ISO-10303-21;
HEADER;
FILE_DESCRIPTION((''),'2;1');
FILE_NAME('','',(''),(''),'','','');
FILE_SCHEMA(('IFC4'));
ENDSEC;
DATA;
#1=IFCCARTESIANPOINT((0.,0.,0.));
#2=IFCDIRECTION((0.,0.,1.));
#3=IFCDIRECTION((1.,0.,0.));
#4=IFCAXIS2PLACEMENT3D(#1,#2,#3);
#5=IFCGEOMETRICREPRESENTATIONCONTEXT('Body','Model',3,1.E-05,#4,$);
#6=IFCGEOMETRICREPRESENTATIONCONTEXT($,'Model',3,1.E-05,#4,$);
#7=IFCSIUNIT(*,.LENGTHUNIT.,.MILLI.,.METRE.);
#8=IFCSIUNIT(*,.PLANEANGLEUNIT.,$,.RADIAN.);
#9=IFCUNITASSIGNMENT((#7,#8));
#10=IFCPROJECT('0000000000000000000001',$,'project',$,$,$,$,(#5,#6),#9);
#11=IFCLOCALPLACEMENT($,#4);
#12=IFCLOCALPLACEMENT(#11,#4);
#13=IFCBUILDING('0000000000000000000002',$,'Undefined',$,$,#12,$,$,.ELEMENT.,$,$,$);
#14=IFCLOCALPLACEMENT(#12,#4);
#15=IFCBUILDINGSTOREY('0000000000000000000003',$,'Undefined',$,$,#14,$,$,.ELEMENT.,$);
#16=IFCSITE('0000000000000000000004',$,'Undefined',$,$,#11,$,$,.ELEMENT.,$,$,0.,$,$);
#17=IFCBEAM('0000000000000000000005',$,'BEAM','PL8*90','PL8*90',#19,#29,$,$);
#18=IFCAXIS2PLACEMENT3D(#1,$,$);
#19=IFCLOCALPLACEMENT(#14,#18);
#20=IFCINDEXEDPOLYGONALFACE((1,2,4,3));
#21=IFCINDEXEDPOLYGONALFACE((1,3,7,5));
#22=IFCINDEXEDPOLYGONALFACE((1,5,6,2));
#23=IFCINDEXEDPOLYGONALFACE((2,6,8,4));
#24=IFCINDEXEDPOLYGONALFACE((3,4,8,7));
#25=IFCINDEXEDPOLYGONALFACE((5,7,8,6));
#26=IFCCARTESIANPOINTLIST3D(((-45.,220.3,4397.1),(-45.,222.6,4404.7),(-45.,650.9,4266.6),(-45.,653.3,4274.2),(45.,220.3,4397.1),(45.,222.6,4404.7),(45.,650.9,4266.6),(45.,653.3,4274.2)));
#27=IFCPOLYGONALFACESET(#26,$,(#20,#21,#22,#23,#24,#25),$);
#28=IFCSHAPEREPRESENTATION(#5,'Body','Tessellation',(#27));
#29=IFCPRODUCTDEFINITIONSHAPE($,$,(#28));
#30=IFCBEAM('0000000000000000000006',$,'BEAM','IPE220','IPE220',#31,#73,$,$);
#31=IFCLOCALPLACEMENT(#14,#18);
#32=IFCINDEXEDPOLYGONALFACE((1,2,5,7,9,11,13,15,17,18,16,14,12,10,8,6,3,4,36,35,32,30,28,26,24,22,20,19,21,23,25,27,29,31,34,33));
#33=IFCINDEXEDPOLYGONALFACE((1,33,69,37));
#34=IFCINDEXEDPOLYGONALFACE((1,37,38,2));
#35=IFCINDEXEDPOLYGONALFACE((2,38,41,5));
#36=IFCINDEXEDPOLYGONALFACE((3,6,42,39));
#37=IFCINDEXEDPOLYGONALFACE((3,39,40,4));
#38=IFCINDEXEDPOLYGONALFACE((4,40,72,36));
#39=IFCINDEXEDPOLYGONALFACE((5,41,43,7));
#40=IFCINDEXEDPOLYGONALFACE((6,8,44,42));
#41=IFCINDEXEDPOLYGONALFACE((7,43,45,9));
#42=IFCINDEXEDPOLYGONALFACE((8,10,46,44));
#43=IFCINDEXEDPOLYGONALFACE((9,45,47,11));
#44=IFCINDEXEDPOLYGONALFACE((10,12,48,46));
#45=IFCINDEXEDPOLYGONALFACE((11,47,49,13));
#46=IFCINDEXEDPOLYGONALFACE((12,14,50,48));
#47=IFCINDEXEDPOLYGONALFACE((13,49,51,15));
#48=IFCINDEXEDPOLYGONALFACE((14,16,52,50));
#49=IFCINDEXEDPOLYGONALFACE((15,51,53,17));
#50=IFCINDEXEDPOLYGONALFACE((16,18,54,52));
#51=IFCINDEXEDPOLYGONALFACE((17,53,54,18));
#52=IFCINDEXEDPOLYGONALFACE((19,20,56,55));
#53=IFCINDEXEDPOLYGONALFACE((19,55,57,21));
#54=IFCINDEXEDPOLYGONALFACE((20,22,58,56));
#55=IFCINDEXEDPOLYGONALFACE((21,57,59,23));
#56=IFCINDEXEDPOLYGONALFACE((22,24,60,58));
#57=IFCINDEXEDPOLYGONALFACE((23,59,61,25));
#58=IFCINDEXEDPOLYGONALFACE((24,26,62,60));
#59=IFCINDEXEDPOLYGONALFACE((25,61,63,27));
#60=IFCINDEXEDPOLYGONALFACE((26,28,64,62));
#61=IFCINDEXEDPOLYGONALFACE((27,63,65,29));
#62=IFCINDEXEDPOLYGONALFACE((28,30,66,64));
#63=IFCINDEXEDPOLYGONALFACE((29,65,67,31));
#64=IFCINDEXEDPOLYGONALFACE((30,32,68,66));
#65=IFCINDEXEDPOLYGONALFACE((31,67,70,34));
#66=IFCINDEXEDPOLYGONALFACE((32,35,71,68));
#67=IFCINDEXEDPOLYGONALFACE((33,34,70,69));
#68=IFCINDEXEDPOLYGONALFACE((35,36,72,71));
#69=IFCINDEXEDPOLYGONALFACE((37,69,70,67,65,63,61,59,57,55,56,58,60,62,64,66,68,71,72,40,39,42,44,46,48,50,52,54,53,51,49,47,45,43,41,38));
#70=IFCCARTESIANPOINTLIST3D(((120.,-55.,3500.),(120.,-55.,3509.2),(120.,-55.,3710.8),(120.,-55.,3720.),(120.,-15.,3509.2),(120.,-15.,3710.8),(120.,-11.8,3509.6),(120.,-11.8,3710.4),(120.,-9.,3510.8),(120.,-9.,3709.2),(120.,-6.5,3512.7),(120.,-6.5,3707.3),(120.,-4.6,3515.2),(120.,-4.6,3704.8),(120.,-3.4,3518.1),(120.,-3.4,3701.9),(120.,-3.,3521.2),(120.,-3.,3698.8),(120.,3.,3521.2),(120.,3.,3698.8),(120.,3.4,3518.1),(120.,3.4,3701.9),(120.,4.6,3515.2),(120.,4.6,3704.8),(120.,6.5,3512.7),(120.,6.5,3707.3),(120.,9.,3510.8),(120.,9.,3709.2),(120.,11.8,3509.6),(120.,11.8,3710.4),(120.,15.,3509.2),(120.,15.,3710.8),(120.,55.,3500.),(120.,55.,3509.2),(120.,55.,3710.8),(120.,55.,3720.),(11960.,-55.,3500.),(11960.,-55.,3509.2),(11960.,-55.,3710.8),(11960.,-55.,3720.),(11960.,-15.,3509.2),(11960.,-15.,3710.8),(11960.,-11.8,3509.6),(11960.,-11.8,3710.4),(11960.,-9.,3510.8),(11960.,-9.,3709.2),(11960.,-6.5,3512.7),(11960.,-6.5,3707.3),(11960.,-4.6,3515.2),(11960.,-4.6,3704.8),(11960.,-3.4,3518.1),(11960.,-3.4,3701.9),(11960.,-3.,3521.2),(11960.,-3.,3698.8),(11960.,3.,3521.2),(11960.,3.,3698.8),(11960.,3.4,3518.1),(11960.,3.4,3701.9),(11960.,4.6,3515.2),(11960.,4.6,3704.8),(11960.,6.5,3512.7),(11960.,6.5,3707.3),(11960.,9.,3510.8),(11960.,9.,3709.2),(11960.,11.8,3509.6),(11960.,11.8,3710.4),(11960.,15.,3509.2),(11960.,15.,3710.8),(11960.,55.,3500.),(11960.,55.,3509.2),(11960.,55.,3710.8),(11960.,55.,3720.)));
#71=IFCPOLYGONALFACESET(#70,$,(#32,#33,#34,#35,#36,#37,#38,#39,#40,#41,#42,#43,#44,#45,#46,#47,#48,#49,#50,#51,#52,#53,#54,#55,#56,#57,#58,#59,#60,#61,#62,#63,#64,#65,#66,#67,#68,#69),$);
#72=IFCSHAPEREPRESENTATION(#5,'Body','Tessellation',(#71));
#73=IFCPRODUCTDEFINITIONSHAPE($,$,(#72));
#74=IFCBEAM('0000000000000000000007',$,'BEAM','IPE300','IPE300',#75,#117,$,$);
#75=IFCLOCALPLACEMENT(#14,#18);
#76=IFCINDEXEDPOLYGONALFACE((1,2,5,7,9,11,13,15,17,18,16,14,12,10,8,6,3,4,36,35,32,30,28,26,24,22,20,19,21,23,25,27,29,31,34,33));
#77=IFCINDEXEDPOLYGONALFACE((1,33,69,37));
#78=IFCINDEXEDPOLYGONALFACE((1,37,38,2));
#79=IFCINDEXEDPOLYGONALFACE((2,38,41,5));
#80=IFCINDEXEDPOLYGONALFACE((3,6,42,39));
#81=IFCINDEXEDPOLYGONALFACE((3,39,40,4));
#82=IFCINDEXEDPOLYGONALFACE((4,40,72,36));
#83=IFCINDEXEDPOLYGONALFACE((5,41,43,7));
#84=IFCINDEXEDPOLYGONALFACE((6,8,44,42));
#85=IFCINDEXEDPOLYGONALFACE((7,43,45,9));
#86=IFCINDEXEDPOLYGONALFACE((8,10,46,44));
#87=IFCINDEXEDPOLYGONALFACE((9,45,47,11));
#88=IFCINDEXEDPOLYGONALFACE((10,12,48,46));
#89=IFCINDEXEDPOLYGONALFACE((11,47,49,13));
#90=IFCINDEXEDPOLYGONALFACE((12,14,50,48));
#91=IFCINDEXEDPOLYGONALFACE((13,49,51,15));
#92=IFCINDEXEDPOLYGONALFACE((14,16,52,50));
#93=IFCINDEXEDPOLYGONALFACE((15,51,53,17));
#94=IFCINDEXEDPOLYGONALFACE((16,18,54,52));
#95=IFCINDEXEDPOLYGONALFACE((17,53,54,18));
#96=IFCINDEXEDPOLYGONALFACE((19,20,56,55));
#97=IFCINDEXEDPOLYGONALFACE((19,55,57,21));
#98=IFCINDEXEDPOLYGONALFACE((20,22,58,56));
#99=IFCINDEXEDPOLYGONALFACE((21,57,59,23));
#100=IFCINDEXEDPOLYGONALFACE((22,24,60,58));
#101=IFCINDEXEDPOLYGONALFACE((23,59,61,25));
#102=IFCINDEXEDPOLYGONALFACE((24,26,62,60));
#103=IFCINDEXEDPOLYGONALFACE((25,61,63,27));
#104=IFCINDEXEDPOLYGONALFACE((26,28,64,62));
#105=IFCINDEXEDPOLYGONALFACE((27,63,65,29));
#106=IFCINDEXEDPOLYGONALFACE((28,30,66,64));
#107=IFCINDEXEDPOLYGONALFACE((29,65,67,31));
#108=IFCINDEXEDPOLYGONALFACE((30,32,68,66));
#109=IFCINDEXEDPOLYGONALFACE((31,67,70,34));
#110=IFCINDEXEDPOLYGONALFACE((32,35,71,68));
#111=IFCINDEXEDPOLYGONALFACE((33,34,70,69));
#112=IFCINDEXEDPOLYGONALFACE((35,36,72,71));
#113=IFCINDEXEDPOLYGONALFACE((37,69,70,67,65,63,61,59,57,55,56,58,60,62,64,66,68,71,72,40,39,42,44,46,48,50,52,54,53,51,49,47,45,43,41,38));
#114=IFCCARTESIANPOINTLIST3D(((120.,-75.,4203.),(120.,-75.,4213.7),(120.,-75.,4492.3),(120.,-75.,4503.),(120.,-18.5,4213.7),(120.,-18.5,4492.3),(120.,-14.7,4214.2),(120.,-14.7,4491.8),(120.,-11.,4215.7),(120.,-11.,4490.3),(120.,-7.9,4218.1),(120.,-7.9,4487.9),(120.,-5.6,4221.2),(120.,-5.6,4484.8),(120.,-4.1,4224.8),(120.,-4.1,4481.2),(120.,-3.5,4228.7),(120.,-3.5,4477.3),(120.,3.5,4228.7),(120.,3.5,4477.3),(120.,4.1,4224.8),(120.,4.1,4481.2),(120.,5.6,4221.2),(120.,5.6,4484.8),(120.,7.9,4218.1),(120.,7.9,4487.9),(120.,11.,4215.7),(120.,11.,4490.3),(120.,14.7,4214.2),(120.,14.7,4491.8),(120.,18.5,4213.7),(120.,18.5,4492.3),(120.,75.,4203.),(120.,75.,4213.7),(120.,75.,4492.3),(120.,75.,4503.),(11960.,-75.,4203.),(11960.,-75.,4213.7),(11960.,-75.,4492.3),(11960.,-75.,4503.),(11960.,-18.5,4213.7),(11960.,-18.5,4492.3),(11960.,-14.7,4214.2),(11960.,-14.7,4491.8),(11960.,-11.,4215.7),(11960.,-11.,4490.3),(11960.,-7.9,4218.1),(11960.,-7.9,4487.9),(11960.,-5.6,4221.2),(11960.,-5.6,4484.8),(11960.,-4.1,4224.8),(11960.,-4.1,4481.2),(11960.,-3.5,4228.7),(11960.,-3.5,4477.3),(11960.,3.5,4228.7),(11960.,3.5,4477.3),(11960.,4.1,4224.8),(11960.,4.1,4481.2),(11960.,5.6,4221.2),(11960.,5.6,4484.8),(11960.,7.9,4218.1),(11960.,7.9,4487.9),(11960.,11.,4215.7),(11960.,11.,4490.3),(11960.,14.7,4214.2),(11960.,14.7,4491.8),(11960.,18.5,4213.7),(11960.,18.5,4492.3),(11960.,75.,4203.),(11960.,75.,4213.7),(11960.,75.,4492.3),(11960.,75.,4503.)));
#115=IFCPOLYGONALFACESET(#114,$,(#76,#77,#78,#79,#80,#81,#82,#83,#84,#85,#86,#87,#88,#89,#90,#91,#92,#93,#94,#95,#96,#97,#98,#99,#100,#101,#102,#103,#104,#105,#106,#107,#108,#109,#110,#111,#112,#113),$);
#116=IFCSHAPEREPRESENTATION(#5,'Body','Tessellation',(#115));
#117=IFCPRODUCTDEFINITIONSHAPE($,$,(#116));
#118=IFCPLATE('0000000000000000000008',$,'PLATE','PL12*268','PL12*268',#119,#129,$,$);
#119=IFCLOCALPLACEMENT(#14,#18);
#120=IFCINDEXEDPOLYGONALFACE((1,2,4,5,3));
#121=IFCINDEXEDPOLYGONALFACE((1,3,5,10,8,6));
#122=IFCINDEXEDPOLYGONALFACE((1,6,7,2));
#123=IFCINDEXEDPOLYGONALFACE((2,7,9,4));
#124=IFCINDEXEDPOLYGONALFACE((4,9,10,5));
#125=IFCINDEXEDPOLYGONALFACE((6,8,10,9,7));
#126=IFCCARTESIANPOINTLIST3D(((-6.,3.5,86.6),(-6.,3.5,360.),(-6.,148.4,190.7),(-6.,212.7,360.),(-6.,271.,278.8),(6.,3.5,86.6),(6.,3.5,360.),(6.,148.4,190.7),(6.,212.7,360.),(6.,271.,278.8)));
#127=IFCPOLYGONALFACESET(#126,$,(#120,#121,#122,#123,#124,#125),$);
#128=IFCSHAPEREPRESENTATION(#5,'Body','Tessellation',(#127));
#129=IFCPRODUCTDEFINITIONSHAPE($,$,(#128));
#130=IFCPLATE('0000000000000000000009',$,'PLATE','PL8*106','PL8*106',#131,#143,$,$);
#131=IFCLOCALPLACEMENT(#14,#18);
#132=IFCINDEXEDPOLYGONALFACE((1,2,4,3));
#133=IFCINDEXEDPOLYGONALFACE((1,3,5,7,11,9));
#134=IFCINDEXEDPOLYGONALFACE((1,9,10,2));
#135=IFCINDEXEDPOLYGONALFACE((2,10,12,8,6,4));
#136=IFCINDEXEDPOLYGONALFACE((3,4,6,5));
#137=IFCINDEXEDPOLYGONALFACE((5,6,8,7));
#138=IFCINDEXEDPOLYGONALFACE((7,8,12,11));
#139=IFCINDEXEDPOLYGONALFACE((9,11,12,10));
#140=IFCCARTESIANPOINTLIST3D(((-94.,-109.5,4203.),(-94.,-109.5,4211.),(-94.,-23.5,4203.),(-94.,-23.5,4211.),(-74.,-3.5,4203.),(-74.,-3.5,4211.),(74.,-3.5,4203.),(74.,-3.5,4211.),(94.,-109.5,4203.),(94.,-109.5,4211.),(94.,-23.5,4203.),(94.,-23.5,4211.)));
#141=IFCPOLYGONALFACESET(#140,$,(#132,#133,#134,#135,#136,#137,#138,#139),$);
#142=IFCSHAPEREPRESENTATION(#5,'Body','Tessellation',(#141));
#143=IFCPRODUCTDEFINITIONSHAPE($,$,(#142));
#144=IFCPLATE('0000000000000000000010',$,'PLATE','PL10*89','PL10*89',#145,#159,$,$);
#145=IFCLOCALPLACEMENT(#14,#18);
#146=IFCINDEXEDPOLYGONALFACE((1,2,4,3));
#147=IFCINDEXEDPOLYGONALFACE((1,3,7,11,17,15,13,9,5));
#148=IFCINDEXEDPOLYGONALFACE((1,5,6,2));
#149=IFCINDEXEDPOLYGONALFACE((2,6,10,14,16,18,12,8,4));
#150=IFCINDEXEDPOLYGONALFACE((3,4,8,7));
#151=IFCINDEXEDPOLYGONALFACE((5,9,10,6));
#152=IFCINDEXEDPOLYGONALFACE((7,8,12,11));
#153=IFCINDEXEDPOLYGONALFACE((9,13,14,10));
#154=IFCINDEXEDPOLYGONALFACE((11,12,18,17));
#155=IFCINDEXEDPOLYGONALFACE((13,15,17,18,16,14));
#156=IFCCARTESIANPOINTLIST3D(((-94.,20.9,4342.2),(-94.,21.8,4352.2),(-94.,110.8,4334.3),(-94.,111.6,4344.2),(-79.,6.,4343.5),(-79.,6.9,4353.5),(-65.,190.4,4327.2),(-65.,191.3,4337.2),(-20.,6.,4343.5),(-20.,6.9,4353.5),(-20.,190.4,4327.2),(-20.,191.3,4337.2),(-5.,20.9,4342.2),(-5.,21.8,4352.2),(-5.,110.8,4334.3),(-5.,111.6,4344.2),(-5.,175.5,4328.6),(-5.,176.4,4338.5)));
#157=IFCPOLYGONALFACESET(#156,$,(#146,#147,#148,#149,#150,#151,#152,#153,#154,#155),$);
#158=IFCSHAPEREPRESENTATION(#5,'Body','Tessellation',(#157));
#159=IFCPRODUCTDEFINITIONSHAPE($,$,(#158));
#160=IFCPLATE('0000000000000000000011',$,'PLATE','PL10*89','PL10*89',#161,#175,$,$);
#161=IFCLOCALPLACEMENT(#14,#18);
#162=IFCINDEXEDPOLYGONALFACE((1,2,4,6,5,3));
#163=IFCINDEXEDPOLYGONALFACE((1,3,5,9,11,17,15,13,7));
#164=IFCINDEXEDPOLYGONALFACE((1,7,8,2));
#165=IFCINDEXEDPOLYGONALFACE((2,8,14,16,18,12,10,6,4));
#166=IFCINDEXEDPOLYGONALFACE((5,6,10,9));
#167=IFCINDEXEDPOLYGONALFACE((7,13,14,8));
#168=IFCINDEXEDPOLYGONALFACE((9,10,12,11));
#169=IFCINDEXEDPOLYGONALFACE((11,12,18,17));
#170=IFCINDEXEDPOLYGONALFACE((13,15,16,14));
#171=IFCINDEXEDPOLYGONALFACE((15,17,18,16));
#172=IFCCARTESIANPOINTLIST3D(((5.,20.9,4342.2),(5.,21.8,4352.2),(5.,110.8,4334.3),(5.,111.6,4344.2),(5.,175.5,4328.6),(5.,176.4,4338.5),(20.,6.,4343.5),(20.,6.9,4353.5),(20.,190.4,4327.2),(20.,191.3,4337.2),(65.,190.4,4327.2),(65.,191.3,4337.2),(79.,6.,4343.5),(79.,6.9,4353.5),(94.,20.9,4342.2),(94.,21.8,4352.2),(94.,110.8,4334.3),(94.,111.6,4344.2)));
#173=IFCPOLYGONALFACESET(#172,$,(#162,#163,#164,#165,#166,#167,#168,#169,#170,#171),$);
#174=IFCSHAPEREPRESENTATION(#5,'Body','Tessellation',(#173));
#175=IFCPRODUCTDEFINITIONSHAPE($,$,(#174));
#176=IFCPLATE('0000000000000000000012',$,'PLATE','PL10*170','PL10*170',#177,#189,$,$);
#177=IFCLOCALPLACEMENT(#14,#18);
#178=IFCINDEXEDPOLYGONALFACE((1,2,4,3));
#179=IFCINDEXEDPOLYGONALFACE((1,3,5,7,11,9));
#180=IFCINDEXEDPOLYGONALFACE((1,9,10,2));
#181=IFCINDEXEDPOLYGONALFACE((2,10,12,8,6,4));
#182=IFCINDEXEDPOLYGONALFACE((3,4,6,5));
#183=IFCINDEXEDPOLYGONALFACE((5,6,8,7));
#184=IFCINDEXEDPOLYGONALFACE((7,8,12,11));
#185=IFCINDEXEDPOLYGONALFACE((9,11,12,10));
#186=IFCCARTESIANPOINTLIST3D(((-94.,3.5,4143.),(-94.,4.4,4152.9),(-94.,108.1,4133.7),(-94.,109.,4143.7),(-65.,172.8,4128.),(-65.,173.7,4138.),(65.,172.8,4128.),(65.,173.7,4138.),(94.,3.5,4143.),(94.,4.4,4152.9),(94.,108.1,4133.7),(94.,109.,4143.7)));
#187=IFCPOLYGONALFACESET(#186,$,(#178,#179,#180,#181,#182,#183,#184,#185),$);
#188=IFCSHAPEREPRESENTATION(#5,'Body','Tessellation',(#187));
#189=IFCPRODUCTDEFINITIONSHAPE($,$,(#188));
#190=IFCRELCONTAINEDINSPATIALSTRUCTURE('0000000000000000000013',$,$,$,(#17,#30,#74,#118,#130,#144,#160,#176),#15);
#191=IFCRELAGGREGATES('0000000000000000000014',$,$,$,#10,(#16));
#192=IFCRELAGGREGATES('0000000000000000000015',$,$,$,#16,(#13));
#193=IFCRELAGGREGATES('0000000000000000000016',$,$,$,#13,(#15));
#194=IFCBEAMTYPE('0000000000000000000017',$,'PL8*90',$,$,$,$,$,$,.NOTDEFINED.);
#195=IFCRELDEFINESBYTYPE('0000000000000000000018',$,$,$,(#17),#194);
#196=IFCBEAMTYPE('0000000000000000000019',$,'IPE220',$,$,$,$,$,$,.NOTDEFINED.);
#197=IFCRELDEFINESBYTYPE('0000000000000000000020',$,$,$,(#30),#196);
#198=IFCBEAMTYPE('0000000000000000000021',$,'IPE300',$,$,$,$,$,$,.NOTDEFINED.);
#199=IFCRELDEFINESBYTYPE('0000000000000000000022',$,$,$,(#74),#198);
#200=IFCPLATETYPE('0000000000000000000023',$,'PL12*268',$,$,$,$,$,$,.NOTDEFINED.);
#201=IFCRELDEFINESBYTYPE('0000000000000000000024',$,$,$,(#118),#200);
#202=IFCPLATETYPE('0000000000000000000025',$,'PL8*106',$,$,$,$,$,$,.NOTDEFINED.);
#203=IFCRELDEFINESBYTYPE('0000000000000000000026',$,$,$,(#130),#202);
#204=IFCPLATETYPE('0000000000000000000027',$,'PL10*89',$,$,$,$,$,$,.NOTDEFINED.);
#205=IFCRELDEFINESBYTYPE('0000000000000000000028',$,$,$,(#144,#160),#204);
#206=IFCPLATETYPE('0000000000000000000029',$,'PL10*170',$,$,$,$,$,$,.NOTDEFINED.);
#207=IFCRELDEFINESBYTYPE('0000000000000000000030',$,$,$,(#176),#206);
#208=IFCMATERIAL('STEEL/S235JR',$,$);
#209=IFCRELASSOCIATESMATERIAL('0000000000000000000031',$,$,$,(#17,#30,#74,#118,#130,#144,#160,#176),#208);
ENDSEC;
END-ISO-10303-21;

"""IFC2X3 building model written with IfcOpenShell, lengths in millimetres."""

from ifc_helpers import new_model, si_unit, frame, origin_with_axes, origin_2d_with_axis, place, context, project, spatial, polyline, rectangle, i_section, outline, extrude, material, type_object, element, save


model = new_model("IFC2X3")

# Units and contexts
model_context_1 = context("Model", 3, precision=1e-05, world=origin_with_axes(), identifier="Body")
model_context_2 = context("Model", 3, precision=1e-05, world=origin_with_axes())
ifc_project = project(units=[si_unit("LENGTHUNIT", "METRE", prefix="MILLI"), si_unit("PLANEANGLEUNIT", "RADIAN")], contexts=[model_context_1, model_context_2])

# Site, building, storey
site_placement = place(None, origin_with_axes())
site = spatial("IfcSite", under=ifc_project, at=site_placement, Name="Undefined", CompositionType="ELEMENT", RefElevation=0.0)
building_placement = place(site_placement, origin_with_axes())
building = spatial("IfcBuilding", under=site, at=building_placement, Name="Undefined", CompositionType="ELEMENT")
storey_placement = place(building_placement, origin_with_axes())
storey = spatial("IfcBuildingStorey", under=building, at=storey_placement, Name="Undefined", CompositionType="ELEMENT")

# Shared definitions
ifc_material = material(Name="STEEL/S235JR")

# Beams
beam_type_1 = type_object("IfcBeamType", Name="PL8*90", PredefinedType="NOTDEFINED")
beam_1_placement = place(storey_placement, frame((0.0, 221.4, 4400.9), z_axis=(-1.0, 0.0, 0.0), x_axis=(0.0, 0.957026, -0.290002)))
element("IfcBeam", 1, at=beam_1_placement, inside=storey, type_object=beam_type_1, material=ifc_material, Name="BEAM", Description="PL8*90", ObjectType="PL8*90", context=model_context_1, shape_type="SweptSolid", body=[
    extrude(rectangle(XDim=8.0, YDim=90.0, at=origin_2d_with_axis()), frame((450.0, 0.0, 0.0), z_axis=(-1.0, 0.0, 0.0), x_axis=(0.0, -1.0, 0.0)), (0.0, 0.0, 1.0), 450.0),
])
beam_type_2 = type_object("IfcBeamType", Name="IPE220", PredefinedType="NOTDEFINED")
beam_2_placement = place(storey_placement, frame((40.0, 0.0, 3610.0), z_axis=(0.0, 0.0, 1.0), x_axis=(1.0, 0.0, 0.0)))
element("IfcBeam", 2, at=beam_2_placement, inside=storey, type_object=beam_type_2, material=ifc_material, Name="BEAM", Description="IPE220", ObjectType="IPE220", context=model_context_1, shape_type="SweptSolid", body=[
    extrude(i_section(OverallWidth=110.0, OverallDepth=220.0, WebThickness=5.9, FlangeThickness=9.2, FilletRadius=12.0, at=origin_2d_with_axis()), frame((11920.0, 0.0, 0.0), z_axis=(-1.0, 0.0, 0.0), x_axis=(0.0, -1.0, 0.0)), (0.0, 0.0, 1.0), 11840.0),
])
beam_type_3 = type_object("IfcBeamType", Name="IPE300", PredefinedType="NOTDEFINED")
beam_3_placement = place(storey_placement, frame((40.0, 0.0, 4353.0), z_axis=(0.0, 0.0, 1.0), x_axis=(1.0, 0.0, 0.0)))
element("IfcBeam", 3, at=beam_3_placement, inside=storey, type_object=beam_type_3, material=ifc_material, Name="BEAM", Description="IPE300", ObjectType="IPE300", context=model_context_1, shape_type="SweptSolid", body=[
    extrude(i_section(OverallWidth=150.0, OverallDepth=300.0, WebThickness=7.1, FlangeThickness=10.7, FilletRadius=15.0, at=origin_2d_with_axis()), frame((11920.0, 0.0, 0.0), z_axis=(-1.0, 0.0, 0.0), x_axis=(0.0, -1.0, 0.0)), (0.0, 0.0, 1.0), 11840.0),
])

# Plates
plate_type_1 = type_object("IfcPlateType", Name="PL12*268", PredefinedType="NOTDEFINED")
plate_1_placement = place(storey_placement, frame((0.0, 3.5, 86.6), z_axis=(-1.0, 0.0, 0.0), x_axis=(0.0, 0.0, 1.0)))
element("IfcPlate", 4, at=plate_1_placement, inside=storey, type_object=plate_type_1, material=ifc_material, Name="PLATE", Description="PL12*268", ObjectType="PL12*268", context=model_context_1, shape_type="SweptSolid", body=[
    extrude(outline(polyline([(0.0, 0.0), (273.4, 0.0), (273.4, 209.2), (192.2, 267.5), (104.1, 144.9), (0.0, 0.0)])), frame((0.0, 0.0, -6.0), z_axis=(0.0, 0.0, 1.0), x_axis=(1.0, 0.0, 0.0)), (0.0, 0.0, 1.0), 12.0),
])
plate_type_2 = type_object("IfcPlateType", Name="PL8*106", PredefinedType="NOTDEFINED")
plate_2_placement = place(storey_placement, frame((94.0, -109.5, 4207.0), z_axis=(0.0, 0.0, 1.0), x_axis=(0.0, 1.0, 0.0)))
element("IfcPlate", 5, at=plate_2_placement, inside=storey, type_object=plate_type_2, material=ifc_material, Name="PLATE", Description="PL8*106", ObjectType="PL8*106", context=model_context_1, shape_type="SweptSolid", body=[
    extrude(outline(polyline([(0.0, 0.0), (86.0, 0.0), (106.0, 20.0), (106.0, 168.0), (86.0, 188.0), (0.0, 188.0), (0.0, 0.0)])), frame((0.0, 0.0, -4.0), z_axis=(0.0, 0.0, 1.0), x_axis=(1.0, 0.0, 0.0)), (0.0, 0.0, 1.0), 8.0),
])
plate_type_3 = type_object("IfcPlateType", Name="PL10*89", PredefinedType="NOTDEFINED")
for number, where, z_axis, x_axis, name in (
    (6, (-5.0, 190.9, 4332.2), (0.0, -0.08801, -0.99612), (0.0, -0.99612, 0.08801), "PLATE"),
    (7, (5.0, 190.9, 4332.2), (0.0, 0.08801, 0.99612), (0.0, -0.99612, 0.08801), "PLATE"),
):
    element("IfcPlate", number, at=place(storey_placement, frame(where, z_axis=z_axis, x_axis=x_axis)), inside=storey, type_object=plate_type_3, material=ifc_material, Name=name, Description="PL10*89", ObjectType="PL10*89", context=model_context_1, shape_type="SweptSolid", body=[
        extrude(outline(polyline([(0.0, 15.0), (15.0, 0.0), (80.0, 0.0), (170.2, 0.0), (185.2, 15.0), (185.2, 74.0), (170.2, 89.0), (80.0, 89.0), (0.0, 60.0), (0.0, 15.0)])), frame((0.0, 0.0, -5.0), z_axis=(0.0, 0.0, 1.0), x_axis=(1.0, 0.0, 0.0)), (0.0, 0.0, 1.0), 10.0),
    ])
plate_type_4 = type_object("IfcPlateType", Name="PL10*170", PredefinedType="NOTDEFINED")
plate_3_placement = place(storey_placement, frame((-65.0, 173.3, 4133.0), z_axis=(0.0, 0.08801, 0.99612), x_axis=(-0.407441, -0.909688, 0.080373)))
element("IfcPlate", 8, at=plate_3_placement, inside=storey, type_object=plate_type_4, material=ifc_material, Name="PLATE", Description="PL10*170", ObjectType="PL10*170", context=model_context_1, shape_type="SweptSolid", body=[
    extrude(outline(polyline([(0.0, 0.0), (71.2, 0.0), (167.1, 42.8), (90.5, 214.5), (-5.4, 171.7), (-53.0, 118.7), (0.0, 0.0)])), frame((0.0, 0.0, -5.0), z_axis=(0.0, 0.0, 1.0), x_axis=(1.0, 0.0, 0.0)), (0.0, 0.0, 1.0), 10.0),
])

save(model, "model.ifc")
